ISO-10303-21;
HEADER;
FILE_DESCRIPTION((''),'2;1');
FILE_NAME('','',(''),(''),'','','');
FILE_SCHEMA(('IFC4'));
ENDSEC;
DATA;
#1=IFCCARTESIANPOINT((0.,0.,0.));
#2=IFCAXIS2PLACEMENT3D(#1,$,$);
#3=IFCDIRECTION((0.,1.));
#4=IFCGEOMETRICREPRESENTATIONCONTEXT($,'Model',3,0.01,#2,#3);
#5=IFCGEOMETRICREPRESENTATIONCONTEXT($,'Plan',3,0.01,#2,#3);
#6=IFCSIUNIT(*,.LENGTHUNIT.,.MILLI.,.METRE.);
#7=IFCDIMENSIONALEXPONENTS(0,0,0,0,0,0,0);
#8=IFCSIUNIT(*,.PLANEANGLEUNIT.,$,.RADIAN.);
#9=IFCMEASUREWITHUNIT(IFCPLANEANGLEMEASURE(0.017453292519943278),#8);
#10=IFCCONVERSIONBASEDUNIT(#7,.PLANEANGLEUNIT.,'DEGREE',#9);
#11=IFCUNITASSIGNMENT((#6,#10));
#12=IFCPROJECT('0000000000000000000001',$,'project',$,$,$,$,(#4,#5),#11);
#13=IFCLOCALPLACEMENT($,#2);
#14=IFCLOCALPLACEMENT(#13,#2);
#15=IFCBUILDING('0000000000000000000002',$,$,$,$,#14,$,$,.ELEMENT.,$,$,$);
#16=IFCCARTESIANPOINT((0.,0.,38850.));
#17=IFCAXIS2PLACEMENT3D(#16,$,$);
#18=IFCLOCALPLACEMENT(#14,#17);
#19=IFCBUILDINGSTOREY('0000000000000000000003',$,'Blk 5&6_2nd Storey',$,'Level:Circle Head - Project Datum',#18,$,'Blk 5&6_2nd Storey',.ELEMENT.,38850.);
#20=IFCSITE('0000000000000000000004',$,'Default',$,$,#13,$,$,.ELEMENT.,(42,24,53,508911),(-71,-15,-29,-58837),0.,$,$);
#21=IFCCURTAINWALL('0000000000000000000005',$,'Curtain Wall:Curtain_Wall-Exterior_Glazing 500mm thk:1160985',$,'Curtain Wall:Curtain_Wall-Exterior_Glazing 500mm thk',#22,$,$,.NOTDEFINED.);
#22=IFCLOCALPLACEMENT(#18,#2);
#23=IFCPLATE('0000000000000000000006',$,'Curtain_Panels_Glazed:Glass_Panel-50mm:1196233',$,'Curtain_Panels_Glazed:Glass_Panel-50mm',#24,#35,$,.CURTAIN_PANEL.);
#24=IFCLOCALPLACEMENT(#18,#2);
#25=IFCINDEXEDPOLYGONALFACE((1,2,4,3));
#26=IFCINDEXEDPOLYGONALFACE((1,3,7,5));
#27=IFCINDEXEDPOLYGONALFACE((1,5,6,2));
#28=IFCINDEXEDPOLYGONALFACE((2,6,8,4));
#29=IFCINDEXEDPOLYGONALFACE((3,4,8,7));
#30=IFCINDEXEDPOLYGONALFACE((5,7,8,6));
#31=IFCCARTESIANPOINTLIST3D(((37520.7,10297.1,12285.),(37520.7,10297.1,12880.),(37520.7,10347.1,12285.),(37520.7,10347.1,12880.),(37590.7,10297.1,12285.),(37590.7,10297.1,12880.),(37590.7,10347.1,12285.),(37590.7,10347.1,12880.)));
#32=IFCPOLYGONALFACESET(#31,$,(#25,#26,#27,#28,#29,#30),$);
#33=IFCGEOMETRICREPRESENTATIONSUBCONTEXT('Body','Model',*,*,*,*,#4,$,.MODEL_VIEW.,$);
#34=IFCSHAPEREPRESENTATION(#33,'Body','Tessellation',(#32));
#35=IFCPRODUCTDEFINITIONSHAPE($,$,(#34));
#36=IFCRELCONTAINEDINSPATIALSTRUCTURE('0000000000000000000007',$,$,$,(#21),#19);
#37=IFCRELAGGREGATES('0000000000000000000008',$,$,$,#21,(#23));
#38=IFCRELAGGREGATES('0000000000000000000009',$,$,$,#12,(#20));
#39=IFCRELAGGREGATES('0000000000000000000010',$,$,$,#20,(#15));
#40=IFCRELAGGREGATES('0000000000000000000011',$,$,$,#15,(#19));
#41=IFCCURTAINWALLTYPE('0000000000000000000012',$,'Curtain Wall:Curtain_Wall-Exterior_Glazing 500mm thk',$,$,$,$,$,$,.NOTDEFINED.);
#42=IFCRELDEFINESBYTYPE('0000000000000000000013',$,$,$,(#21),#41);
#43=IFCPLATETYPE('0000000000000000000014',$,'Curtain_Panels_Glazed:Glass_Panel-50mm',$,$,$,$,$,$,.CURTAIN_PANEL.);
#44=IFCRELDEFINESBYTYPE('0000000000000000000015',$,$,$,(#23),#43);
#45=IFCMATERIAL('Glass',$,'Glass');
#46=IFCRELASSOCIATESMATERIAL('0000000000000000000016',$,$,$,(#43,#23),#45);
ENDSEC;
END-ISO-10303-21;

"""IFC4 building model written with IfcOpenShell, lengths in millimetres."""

from ifc_helpers import new_model, entity, si_unit, converted_unit, direction, frame, origin, place, context, subcontext, project, spatial, indexed_curve, outline, extrude, source, transform, mapped, material, type_object, type_shapes, element, aggregate, save


model = new_model("IFC4")

# Units and contexts
model_context = context("Model", 3, precision=0.01, world=origin(), true_north=direction((0.0, 1.0)))
plan_context = context("Plan", 3, precision=0.01, world=origin(), true_north=direction((0.0, 1.0)))
body_context = subcontext(model_context, "Body", "Model", "MODEL_VIEW")
ifc_project = project(units=[si_unit("LENGTHUNIT", "METRE", prefix="MILLI"), converted_unit("PLANEANGLEUNIT", "DEGREE", entity("IfcPlaneAngleMeasure", 0.017453292519943278), si_unit("PLANEANGLEUNIT", "RADIAN"), dimensions=[0, 0, 0, 0, 0, 0, 0])], contexts=[model_context, plan_context])

# Site, building, storey
site_placement = place(None, origin())
site = spatial("IfcSite", under=ifc_project, at=site_placement, Name="Default", CompositionType="ELEMENT", RefLatitude=(42, 24, 53, 508911), RefLongitude=(-71, -15, -29, -58837), RefElevation=0.0)
building_placement = place(site_placement, origin())
building = spatial("IfcBuilding", under=site, at=building_placement, CompositionType="ELEMENT")
storey_placement = place(building_placement, frame((0.0, 0.0, 38850.0)))
storey = spatial("IfcBuildingStorey", under=building, at=storey_placement, Name="Blk 5&6_2nd Storey", ObjectType="Level:Circle Head - Project Datum", LongName="Blk 5&6_2nd Storey", CompositionType="ELEMENT", Elevation=38850.0)

# Curtain wall, plate
curtain_wall_type = type_object("IfcCurtainWallType", Name="Curtain Wall:Curtain_Wall-Exterior_Glazing 500mm thk", PredefinedType="NOTDEFINED")
curtain_wall_placement = place(storey_placement, frame((0.0, 0.0, -38850.0)))
curtain_wall = element("IfcCurtainWall", 1, at=curtain_wall_placement, inside=storey, type_object=curtain_wall_type, Name="Curtain Wall:Curtain_Wall-Exterior_Glazing 500mm thk:1160985", ObjectType="Curtain Wall:Curtain_Wall-Exterior_Glazing 500mm thk", PredefinedType="NOTDEFINED")
ifc_material_1 = material(Name="Glass", Category="Glass")
plate_type_1 = type_object("IfcPlateType", Name="Curtain_Panels_Glazed:Glass_Panel-50mm", PredefinedType="CURTAIN_PANEL", material=ifc_material_1)
shared_shape_1 = source(origin(), body_context, "Body", "SweptSolid", [
    extrude(outline(indexed_curve([(-25.0, -35.0), (25.0, -35.0), (25.0, 35.0), (-25.0, 35.0), (-25.0, -35.0)], self_intersect=False)), frame((0.0, 250.0, 0.0), z_axis=(0.0, 0.0, 1.0), x_axis=(0.0, 1.0, 0.0)), (0.0, 0.0, 1.0), 595.0),
])
type_shapes(plate_type_1, [shared_shape_1])
plate_1_placement = place(curtain_wall_placement, frame((37555.7, 10572.1, 51135.0), z_axis=(0.0, 0.0, 1.0), x_axis=(-1.0, 0.0, 0.0)))
plate_1 = element("IfcPlate", 2, at=plate_1_placement, type_object=plate_type_1, material=ifc_material_1, Name="Curtain_Panels_Glazed:Glass_Panel-50mm:1196233", ObjectType="Curtain_Panels_Glazed:Glass_Panel-50mm", PredefinedType="CURTAIN_PANEL", context=body_context, shape_type="MappedRepresentation", body=[
    mapped(shared_shape_1, transform((0.0, 0.0, 0.0), scale=1.0)),
])
aggregate(curtain_wall, [plate_1])

save(model, "model.ifc")
